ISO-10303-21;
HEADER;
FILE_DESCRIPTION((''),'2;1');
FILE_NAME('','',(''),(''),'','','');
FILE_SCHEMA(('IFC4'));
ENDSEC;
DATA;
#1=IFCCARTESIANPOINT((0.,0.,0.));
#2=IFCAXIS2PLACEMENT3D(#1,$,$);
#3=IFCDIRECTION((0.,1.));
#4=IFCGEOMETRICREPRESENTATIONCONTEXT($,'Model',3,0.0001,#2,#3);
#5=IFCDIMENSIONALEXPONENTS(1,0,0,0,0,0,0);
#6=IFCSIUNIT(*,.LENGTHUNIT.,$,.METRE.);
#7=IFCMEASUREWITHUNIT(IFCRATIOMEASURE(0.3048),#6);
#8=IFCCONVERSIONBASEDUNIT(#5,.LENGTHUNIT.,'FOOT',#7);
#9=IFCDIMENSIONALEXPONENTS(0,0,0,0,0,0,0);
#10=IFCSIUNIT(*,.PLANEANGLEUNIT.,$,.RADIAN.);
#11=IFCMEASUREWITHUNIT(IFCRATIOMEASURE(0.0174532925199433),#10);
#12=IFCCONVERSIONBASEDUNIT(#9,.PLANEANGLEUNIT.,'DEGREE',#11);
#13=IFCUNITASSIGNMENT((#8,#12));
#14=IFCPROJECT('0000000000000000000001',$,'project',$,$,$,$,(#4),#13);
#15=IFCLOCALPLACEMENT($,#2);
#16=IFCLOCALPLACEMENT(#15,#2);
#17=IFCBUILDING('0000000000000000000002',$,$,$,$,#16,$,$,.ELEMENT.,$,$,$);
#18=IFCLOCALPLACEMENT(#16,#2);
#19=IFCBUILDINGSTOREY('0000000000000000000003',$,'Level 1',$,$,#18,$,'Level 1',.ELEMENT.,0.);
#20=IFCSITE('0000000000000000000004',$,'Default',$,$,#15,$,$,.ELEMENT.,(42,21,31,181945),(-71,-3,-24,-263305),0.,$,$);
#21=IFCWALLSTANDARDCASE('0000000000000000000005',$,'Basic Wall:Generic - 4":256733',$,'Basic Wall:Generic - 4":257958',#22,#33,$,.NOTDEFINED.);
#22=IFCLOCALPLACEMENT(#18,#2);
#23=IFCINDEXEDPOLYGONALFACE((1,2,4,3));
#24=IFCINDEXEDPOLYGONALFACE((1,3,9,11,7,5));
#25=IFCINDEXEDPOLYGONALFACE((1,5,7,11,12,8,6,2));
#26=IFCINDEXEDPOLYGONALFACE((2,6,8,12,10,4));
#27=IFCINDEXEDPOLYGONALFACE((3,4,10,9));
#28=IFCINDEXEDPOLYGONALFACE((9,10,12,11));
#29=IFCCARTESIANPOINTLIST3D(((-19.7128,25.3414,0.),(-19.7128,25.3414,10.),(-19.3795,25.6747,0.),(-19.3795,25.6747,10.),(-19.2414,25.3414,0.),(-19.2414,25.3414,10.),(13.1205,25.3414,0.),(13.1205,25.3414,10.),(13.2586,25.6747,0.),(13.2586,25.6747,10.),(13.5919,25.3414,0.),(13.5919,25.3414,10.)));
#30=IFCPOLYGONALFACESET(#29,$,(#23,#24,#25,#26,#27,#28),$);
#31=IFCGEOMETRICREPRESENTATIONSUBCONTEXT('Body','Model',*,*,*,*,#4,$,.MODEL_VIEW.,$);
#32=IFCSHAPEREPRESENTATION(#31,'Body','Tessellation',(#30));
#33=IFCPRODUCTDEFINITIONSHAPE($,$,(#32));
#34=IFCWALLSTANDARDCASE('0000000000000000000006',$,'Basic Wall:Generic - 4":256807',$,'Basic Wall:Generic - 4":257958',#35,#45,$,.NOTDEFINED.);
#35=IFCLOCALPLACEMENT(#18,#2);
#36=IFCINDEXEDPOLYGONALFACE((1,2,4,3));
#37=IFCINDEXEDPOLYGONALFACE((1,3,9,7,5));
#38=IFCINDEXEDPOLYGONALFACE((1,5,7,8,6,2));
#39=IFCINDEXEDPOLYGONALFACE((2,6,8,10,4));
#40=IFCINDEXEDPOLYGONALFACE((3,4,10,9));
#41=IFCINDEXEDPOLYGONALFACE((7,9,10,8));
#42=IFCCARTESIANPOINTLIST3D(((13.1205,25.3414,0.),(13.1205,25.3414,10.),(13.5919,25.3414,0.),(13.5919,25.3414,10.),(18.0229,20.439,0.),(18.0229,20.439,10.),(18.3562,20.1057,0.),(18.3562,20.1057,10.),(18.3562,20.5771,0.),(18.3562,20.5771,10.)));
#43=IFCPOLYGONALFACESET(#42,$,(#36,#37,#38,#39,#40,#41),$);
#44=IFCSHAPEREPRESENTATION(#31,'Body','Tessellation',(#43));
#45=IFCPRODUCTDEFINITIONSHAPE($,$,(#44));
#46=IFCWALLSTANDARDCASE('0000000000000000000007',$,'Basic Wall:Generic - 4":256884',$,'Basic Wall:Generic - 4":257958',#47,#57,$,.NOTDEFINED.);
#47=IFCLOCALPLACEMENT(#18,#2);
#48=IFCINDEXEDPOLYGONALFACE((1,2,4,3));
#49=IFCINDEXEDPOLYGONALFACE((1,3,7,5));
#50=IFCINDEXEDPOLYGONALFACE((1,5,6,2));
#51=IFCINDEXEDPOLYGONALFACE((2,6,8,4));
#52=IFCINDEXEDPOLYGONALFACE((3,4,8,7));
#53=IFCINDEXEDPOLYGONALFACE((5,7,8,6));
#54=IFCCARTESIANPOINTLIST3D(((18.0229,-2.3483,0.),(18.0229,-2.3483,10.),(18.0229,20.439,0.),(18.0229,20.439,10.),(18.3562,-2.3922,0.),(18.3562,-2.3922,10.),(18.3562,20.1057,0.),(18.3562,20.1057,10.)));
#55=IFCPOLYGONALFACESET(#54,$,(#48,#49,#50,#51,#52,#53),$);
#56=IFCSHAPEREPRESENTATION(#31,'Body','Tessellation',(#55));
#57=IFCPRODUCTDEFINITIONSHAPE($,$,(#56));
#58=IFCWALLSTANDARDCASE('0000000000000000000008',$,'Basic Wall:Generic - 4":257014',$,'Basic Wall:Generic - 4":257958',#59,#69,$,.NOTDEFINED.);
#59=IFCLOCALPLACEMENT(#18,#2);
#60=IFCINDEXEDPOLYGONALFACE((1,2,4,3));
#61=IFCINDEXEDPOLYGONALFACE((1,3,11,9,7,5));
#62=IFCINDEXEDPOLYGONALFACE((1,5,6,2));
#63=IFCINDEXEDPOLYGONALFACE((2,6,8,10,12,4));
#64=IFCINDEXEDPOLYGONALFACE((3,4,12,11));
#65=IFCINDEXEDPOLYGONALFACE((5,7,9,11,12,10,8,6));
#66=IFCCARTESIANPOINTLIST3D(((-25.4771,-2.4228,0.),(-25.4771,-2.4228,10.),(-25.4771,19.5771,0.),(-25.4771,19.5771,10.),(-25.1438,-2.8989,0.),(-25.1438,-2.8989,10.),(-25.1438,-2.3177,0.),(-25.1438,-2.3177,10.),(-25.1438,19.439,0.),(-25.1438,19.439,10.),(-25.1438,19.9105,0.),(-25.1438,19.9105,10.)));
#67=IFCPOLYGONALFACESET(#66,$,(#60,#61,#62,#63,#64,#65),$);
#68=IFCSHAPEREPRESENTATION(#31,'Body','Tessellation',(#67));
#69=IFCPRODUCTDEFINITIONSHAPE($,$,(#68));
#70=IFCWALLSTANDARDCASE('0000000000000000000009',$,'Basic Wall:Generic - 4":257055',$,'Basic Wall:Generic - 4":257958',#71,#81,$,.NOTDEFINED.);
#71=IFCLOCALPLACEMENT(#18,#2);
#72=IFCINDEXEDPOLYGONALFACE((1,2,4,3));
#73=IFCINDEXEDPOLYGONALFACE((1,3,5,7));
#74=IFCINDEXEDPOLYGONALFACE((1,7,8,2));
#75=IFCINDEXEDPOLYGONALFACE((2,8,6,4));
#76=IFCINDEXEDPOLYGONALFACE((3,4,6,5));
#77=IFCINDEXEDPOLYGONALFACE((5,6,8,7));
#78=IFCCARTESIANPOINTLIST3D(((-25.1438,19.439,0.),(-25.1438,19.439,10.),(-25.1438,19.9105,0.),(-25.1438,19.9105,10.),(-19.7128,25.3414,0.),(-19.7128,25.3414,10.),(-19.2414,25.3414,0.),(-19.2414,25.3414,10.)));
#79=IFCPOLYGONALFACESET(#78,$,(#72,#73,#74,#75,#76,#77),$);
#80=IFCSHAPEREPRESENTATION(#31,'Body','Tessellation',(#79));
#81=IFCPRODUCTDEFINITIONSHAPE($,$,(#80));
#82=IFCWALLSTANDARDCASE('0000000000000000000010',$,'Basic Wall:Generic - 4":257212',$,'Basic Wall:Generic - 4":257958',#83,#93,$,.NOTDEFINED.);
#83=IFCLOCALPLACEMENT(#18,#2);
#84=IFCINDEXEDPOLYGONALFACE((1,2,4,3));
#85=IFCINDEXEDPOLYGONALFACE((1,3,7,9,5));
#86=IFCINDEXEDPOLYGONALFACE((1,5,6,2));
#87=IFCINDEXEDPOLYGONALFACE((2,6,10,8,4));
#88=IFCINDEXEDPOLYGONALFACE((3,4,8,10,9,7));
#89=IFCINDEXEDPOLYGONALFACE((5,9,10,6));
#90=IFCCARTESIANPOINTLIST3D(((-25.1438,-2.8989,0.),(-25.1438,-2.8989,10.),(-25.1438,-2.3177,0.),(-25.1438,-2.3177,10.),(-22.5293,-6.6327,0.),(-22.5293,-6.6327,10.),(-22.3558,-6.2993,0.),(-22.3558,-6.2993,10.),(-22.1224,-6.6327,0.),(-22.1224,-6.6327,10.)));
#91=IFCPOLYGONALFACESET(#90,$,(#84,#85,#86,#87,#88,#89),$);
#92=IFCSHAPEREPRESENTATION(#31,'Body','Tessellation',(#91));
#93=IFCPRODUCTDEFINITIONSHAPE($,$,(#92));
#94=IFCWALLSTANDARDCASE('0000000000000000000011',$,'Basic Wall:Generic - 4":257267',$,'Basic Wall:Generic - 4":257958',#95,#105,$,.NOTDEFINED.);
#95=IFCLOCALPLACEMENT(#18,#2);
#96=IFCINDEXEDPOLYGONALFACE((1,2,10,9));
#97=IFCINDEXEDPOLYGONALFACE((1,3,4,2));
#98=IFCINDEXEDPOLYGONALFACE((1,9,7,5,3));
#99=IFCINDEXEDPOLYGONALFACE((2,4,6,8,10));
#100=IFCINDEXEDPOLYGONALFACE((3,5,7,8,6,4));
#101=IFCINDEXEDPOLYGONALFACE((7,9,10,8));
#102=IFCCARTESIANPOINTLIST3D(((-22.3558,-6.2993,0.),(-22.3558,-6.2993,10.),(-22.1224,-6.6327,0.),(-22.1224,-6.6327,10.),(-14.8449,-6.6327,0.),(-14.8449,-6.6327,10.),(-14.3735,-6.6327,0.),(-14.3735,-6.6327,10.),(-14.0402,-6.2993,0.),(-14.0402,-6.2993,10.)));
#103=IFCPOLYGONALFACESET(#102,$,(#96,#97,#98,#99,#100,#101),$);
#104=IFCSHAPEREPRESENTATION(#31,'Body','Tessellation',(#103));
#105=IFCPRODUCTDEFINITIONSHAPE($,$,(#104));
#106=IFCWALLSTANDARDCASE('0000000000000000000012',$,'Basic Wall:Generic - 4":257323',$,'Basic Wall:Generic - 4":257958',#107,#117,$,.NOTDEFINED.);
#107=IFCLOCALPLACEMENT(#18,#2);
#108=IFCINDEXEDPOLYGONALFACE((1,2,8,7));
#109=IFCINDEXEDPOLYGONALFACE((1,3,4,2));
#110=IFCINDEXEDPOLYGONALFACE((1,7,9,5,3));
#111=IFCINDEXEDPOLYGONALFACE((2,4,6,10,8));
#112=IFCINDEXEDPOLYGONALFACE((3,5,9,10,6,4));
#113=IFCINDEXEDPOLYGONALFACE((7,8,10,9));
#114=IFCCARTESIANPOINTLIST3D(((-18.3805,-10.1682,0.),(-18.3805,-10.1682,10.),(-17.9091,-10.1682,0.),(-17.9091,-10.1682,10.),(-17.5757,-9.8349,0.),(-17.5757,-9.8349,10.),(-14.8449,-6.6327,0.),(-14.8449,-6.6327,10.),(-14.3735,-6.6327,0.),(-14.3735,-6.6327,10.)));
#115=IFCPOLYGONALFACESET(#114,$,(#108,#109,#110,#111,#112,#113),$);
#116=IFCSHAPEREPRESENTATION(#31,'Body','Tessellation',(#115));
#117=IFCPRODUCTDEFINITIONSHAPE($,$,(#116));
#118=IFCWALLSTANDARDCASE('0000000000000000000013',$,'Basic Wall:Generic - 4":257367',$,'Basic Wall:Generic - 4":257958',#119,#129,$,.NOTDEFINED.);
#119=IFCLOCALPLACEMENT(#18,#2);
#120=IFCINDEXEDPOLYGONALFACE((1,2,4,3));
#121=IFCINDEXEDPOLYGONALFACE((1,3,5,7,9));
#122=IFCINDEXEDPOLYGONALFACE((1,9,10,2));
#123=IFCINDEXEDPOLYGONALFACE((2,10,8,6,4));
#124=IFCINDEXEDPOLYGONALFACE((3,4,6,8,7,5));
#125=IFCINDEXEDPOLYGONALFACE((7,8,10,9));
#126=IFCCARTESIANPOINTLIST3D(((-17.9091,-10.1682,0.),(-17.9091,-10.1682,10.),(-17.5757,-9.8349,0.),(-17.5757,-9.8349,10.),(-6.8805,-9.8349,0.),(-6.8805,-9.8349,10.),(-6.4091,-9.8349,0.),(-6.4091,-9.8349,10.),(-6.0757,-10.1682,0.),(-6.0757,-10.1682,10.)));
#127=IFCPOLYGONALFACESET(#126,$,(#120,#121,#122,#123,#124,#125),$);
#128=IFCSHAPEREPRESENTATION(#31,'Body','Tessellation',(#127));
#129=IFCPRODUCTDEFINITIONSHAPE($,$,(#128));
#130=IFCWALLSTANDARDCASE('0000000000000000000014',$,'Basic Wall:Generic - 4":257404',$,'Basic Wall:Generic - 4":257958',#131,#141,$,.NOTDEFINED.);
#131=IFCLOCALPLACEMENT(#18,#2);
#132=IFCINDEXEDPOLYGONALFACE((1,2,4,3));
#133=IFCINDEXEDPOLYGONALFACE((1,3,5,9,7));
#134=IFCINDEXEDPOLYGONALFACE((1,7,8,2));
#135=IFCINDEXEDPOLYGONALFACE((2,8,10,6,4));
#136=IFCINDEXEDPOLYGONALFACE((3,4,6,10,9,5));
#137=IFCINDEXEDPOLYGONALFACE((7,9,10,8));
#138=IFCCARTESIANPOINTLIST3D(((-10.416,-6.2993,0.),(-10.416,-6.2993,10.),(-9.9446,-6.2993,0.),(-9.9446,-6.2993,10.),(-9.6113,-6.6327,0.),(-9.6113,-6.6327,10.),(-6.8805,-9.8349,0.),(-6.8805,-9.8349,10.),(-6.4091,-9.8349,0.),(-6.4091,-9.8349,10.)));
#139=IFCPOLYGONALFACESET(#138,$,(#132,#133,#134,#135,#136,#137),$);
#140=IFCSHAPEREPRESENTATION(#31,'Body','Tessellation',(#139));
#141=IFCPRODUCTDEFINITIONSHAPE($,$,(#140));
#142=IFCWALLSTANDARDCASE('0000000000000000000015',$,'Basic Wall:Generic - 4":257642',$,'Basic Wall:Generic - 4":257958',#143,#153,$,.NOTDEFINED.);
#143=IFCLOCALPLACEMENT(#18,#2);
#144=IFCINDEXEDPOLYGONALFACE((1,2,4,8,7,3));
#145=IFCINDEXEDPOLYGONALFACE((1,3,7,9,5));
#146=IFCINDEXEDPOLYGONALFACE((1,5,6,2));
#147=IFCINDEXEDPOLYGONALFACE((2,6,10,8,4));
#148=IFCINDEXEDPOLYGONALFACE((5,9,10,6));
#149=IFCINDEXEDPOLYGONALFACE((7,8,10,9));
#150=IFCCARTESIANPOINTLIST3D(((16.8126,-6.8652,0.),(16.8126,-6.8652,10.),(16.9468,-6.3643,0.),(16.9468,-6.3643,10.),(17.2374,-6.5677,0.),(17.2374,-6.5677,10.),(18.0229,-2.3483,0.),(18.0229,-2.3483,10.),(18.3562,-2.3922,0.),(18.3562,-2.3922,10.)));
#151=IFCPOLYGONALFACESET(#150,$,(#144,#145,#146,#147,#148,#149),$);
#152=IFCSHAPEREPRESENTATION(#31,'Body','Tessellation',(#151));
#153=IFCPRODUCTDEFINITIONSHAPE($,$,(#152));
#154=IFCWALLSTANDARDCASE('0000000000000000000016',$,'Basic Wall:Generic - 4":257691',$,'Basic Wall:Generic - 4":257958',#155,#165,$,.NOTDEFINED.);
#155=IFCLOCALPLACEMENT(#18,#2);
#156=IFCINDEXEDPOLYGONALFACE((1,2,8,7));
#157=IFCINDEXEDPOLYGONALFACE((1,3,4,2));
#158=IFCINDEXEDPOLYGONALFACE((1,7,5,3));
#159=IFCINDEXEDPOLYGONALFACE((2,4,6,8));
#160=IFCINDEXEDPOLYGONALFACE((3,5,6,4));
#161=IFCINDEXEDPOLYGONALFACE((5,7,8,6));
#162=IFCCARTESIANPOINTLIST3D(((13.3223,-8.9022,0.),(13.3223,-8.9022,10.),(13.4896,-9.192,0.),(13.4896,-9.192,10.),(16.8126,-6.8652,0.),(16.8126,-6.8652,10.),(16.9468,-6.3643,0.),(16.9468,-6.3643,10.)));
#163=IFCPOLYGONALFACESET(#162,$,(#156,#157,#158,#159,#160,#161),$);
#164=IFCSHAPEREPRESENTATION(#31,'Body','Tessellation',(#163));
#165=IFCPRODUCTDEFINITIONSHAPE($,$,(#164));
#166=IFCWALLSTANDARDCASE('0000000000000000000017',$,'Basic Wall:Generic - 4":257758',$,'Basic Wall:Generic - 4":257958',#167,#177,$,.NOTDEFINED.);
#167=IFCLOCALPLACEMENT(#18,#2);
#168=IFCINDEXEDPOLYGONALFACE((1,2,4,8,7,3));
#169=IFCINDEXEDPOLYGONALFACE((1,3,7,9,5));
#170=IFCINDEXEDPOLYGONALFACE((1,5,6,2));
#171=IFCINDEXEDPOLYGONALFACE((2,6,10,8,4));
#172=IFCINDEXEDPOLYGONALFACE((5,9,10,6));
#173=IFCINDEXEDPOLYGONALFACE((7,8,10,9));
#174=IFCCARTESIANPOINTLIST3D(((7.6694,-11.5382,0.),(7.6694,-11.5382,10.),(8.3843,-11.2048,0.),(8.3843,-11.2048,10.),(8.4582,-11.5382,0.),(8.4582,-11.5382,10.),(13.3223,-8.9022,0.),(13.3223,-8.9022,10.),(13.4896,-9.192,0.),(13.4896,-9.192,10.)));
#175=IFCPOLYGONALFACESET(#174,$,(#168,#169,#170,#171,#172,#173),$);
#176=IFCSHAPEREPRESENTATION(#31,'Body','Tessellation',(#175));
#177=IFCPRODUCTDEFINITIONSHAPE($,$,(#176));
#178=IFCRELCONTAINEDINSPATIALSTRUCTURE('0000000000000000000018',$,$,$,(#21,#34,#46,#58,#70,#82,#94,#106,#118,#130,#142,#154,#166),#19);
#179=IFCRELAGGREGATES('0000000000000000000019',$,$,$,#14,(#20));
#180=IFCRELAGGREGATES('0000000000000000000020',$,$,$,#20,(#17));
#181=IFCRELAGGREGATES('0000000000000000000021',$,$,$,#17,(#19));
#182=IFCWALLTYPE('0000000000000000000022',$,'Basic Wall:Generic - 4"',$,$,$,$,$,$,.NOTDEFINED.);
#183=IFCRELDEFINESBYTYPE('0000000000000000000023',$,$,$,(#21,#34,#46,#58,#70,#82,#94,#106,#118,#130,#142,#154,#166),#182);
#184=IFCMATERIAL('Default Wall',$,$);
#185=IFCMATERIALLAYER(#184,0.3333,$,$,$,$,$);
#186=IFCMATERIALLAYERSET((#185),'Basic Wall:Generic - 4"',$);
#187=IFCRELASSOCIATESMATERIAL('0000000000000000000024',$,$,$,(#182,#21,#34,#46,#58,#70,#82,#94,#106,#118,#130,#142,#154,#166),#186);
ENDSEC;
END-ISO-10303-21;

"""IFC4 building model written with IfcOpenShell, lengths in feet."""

from ifc_helpers import new_model, entity, si_unit, converted_unit, direction, frame, origin, place, context, subcontext, project, spatial, polyline, outline, extrude, material, layer, layer_set, layer_usage, type_object, element, save


model = new_model("IFC4")

# Units and contexts
model_context = context("Model", 3, precision=0.0001, world=origin(), true_north=direction((0.0, 1.0)))
body_context = subcontext(model_context, "Body", "Model", "MODEL_VIEW")
ifc_project = project(units=[converted_unit("LENGTHUNIT", "FOOT", entity("IfcRatioMeasure", 0.3048), si_unit("LENGTHUNIT", "METRE"), dimensions=[1, 0, 0, 0, 0, 0, 0]), converted_unit("PLANEANGLEUNIT", "DEGREE", entity("IfcRatioMeasure", 0.0174532925199433), si_unit("PLANEANGLEUNIT", "RADIAN"), dimensions=[0, 0, 0, 0, 0, 0, 0])], contexts=[model_context])

# Site, building, storey
site_placement = place(None, origin())
site = spatial("IfcSite", under=ifc_project, at=site_placement, Name="Default", CompositionType="ELEMENT", RefLatitude=(42, 21, 31, 181945), RefLongitude=(-71, -3, -24, -263305), RefElevation=0.0)
building_placement = place(site_placement, origin())
building = spatial("IfcBuilding", under=site, at=building_placement, CompositionType="ELEMENT")
storey_placement = place(building_placement, origin())
storey = spatial("IfcBuildingStorey", under=building, at=storey_placement, Name="Level 1", LongName="Level 1", CompositionType="ELEMENT", Elevation=0.0)

# Walls
ifc_material = material(Name="Default Wall")
ifc_layer = layer(ifc_material, 0.3333)
ifc_layer_set = layer_set([ifc_layer], Name="Basic Wall:Generic - 4\"")
ifc_layer_usage_1 = layer_usage(ifc_layer_set, "AXIS2", "NEGATIVE", 0.1667)
wall_type = type_object("IfcWallType", Name="Basic Wall:Generic - 4\"", PredefinedType="NOTDEFINED", material=ifc_layer_set)
wall_1_placement = place(storey_placement, frame((-19.7128, 25.5081, 0.0)))
element("IfcWallStandardCase", 1, at=wall_1_placement, inside=storey, type_object=wall_type, material=ifc_layer_usage_1, Name="Basic Wall:Generic - 4\":256733", ObjectType="Basic Wall:Generic - 4\":257958", PredefinedType="NOTDEFINED", context=body_context, shape_type="SweptSolid", body=[
    extrude(outline(polyline([(33.3047, -0.1667), (32.9714, 0.1667), (0.3333, 0.1667), (0.0, -0.1667), (0.4714, -0.1667), (32.8333, -0.1667), (33.3047, -0.1667)])), origin(), (0.0, 0.0, 1.0), 10.0),
])
ifc_layer_usage_2 = layer_usage(ifc_layer_set, "AXIS2", "NEGATIVE", 0.1667)
wall_2_placement = place(storey_placement, frame((13.2384, 25.4593, 0.0), z_axis=(0.0, 0.0, 1.0), x_axis=(0.707107, -0.707107, 0.0)))
element("IfcWallStandardCase", 2, at=wall_2_placement, inside=storey, type_object=wall_type, material=ifc_layer_usage_2, Name="Basic Wall:Generic - 4\":256807", ObjectType="Basic Wall:Generic - 4\":257958", PredefinedType="NOTDEFINED", context=body_context, shape_type="SweptSolid", body=[
    extrude(outline(polyline([(7.4044, -0.1667), (7.0711, 0.1667), (0.3333, 0.1667), (0.0, -0.1667), (6.933, -0.1667), (7.4044, -0.1667)])), origin(), (0.0, 0.0, 1.0), 10.0),
])
ifc_layer_usage_3 = layer_usage(ifc_layer_set, "AXIS2", "NEGATIVE", 0.1667)
wall_3_placement = place(storey_placement, frame((18.1896, 20.439, 0.0), z_axis=(0.0, 0.0, 1.0), x_axis=(0.0, -1.0, 0.0)))
element("IfcWallStandardCase", 3, at=wall_3_placement, inside=storey, type_object=wall_type, material=ifc_layer_usage_3, Name="Basic Wall:Generic - 4\":256884", ObjectType="Basic Wall:Generic - 4\":257958", PredefinedType="NOTDEFINED", context=body_context, shape_type="SweptSolid", body=[
    extrude(outline(polyline([(22.7874, -0.1667), (22.8312, 0.1667), (0.3333, 0.1667), (0.0, -0.1667), (22.7874, -0.1667)])), origin(), (0.0, 0.0, 1.0), 10.0),
])
ifc_layer_usage_4 = layer_usage(ifc_layer_set, "AXIS2", "NEGATIVE", 0.1667)
wall_4_placement = place(storey_placement, frame((-25.3104, 19.9105, 0.0), z_axis=(0.0, 0.0, 1.0), x_axis=(0.0, -1.0, 0.0)))
element("IfcWallStandardCase", 4, at=wall_4_placement, inside=storey, type_object=wall_type, material=ifc_layer_usage_4, Name="Basic Wall:Generic - 4\":257014", ObjectType="Basic Wall:Generic - 4\":257958", PredefinedType="NOTDEFINED", context=body_context, shape_type="SweptSolid", body=[
    extrude(outline(polyline([(22.3333, -0.1667), (22.8093, 0.1667), (22.2282, 0.1667), (0.4714, 0.1667), (0.0, 0.1667), (0.3333, -0.1667), (22.3333, -0.1667)])), origin(), (0.0, 0.0, 1.0), 10.0),
])
ifc_layer_usage_5 = layer_usage(ifc_layer_set, "AXIS2", "NEGATIVE", 0.1667)
wall_5_placement = place(storey_placement, frame((-25.2616, 19.5569, 0.0), z_axis=(0.0, 0.0, 1.0), x_axis=(0.707107, 0.707107, 0.0)))
element("IfcWallStandardCase", 5, at=wall_5_placement, inside=storey, type_object=wall_type, material=ifc_layer_usage_5, Name="Basic Wall:Generic - 4\":257055", ObjectType="Basic Wall:Generic - 4\":257958", PredefinedType="NOTDEFINED", context=body_context, shape_type="SweptSolid", body=[
    extrude(outline(polyline([(8.3472, -0.1667), (8.0139, 0.1667), (0.3333, 0.1667), (0.0, -0.1667), (8.3472, -0.1667)])), origin(), (0.0, 0.0, 1.0), 10.0),
])
ifc_layer_usage_6 = layer_usage(ifc_layer_set, "AXIS2", "NEGATIVE", 0.1667)
wall_6_placement = place(storey_placement, frame((-25.2803, -2.4133, 0.0), z_axis=(0.0, 0.0, 1.0), x_axis=(0.573576, -0.819152, 0.0)))
element("IfcWallStandardCase", 6, at=wall_6_placement, inside=storey, type_object=wall_type, material=ifc_layer_usage_6, Name="Basic Wall:Generic - 4\":257212", ObjectType="Basic Wall:Generic - 4\":257958", PredefinedType="NOTDEFINED", context=body_context, shape_type="SweptSolid", body=[
    extrude(outline(polyline([(5.0342, -0.1667), (5.2676, 0.1667), (4.8607, 0.1667), (0.0, 0.1667), (0.476, -0.1667), (5.0342, -0.1667)])), origin(), (0.0, 0.0, 1.0), 10.0),
])
ifc_layer_usage_7 = layer_usage(ifc_layer_set, "AXIS2", "NEGATIVE", 0.1667)
wall_7_placement = place(storey_placement, frame((-22.3558, -6.466, 0.0)))
element("IfcWallStandardCase", 7, at=wall_7_placement, inside=storey, type_object=wall_type, material=ifc_layer_usage_7, Name="Basic Wall:Generic - 4\":257267", ObjectType="Basic Wall:Generic - 4\":257958", PredefinedType="NOTDEFINED", context=body_context, shape_type="SweptSolid", body=[
    extrude(outline(polyline([(7.9823, -0.1667), (8.3156, 0.1667), (0.0, 0.1667), (0.2334, -0.1667), (7.5109, -0.1667), (7.9823, -0.1667)])), origin(), (0.0, 0.0, 1.0), 10.0),
])
ifc_layer_usage_8 = layer_usage(ifc_layer_set, "AXIS2", "NEGATIVE", 0.1667)
wall_8_placement = place(storey_placement, frame((-14.4914, -6.5148, 0.0), z_axis=(0.0, 0.0, 1.0), x_axis=(-0.707107, -0.707107, 0.0)))
element("IfcWallStandardCase", 8, at=wall_8_placement, inside=storey, type_object=wall_type, material=ifc_layer_usage_8, Name="Basic Wall:Generic - 4\":257323", ObjectType="Basic Wall:Generic - 4\":257958", PredefinedType="NOTDEFINED", context=body_context, shape_type="SweptSolid", body=[
    extrude(outline(polyline([(5.3333, -0.1667), (5.0, 0.1667), (4.5286, 0.1667), (0.0, 0.1667), (0.3333, -0.1667), (5.3333, -0.1667)])), origin(), (0.0, 0.0, 1.0), 10.0),
])
ifc_layer_usage_9 = layer_usage(ifc_layer_set, "AXIS2", "NEGATIVE", 0.1667)
wall_9_placement = place(storey_placement, frame((-17.9091, -10.0016, 0.0)))
element("IfcWallStandardCase", 9, at=wall_9_placement, inside=storey, type_object=wall_type, material=ifc_layer_usage_9, Name="Basic Wall:Generic - 4\":257367", ObjectType="Basic Wall:Generic - 4\":257958", PredefinedType="NOTDEFINED", context=body_context, shape_type="SweptSolid", body=[
    extrude(outline(polyline([(11.8333, -0.1667), (11.5, 0.1667), (11.0286, 0.1667), (0.3333, 0.1667), (0.0, -0.1667), (11.8333, -0.1667)])), origin(), (0.0, 0.0, 1.0), 10.0),
])
ifc_layer_usage_10 = layer_usage(ifc_layer_set, "AXIS2", "NEGATIVE", 0.1667)
wall_10_placement = place(storey_placement, frame((-6.5269, -9.9527, 0.0), z_axis=(0.0, 0.0, 1.0), x_axis=(-0.707107, 0.707107, 0.0)))
element("IfcWallStandardCase", 10, at=wall_10_placement, inside=storey, type_object=wall_type, material=ifc_layer_usage_10, Name="Basic Wall:Generic - 4\":257404", ObjectType="Basic Wall:Generic - 4\":257958", PredefinedType="NOTDEFINED", context=body_context, shape_type="SweptSolid", body=[
    extrude(outline(polyline([(5.0, -0.1667), (5.3333, 0.1667), (0.3333, 0.1667), (0.0, -0.1667), (4.5286, -0.1667), (5.0, -0.1667)])), origin(), (0.0, 0.0, 1.0), 10.0),
])
ifc_layer_usage_11 = layer_usage(ifc_layer_set, "AXIS2", "NEGATIVE", 0.1667)
wall_11_placement = place(storey_placement, frame((18.1952, -2.3491, 0.0), z_axis=(0.0, 0.0, 1.0), x_axis=(-0.258819, -0.965926, 0.0)))
element("IfcWallStandardCase", 11, at=wall_11_placement, inside=storey, type_object=wall_type, material=ifc_layer_usage_11, Name="Basic Wall:Generic - 4\":257642", ObjectType="Basic Wall:Generic - 4\":257958", PredefinedType="NOTDEFINED", context=body_context, shape_type="SweptSolid", body=[
    extrude(outline(polyline([(4.7201, -0.1667), (4.3228, 0.1667), (0.0, 0.1667), (0.0439, -0.1667), (4.2015, -0.1667), (4.7201, -0.1667)])), origin(), (0.0, 0.0, 1.0), 10.0),
])
ifc_layer_usage_12 = layer_usage(ifc_layer_set, "AXIS2", "NEGATIVE", 0.1667)
wall_12_placement = place(storey_placement, frame((17.0424, -6.5008, 0.0), z_axis=(0.0, 0.0, 1.0), x_axis=(-0.819152, -0.573576, 0.0)))
element("IfcWallStandardCase", 12, at=wall_12_placement, inside=storey, type_object=wall_type, material=ifc_layer_usage_12, Name="Basic Wall:Generic - 4\":257691", ObjectType="Basic Wall:Generic - 4\":257958", PredefinedType="NOTDEFINED", context=body_context, shape_type="SweptSolid", body=[
    extrude(outline(polyline([(4.4248, -0.1667), (4.4539, 0.1667), (0.3973, 0.1667), (0.0, -0.1667), (4.4248, -0.1667)])), origin(), (0.0, 0.0, 1.0), 10.0),
])
ifc_layer_usage_13 = layer_usage(ifc_layer_set, "AXIS2", "NEGATIVE", 0.1667)
wall_13_placement = place(storey_placement, frame((13.4191, -9.0409, 0.0), z_axis=(0.0, 0.0, 1.0), x_axis=(-0.906308, -0.422618, 0.0)))
element("IfcWallStandardCase", 13, at=wall_13_placement, inside=storey, type_object=wall_type, material=ifc_layer_usage_13, Name="Basic Wall:Generic - 4\":257758", ObjectType="Basic Wall:Generic - 4\":257958", PredefinedType="NOTDEFINED", context=body_context, shape_type="SweptSolid", body=[
    extrude(outline(polyline([(6.2664, -0.1667), (5.5515, 0.1667), (0.0, 0.1667), (0.0292, -0.1667), (5.4776, -0.1667), (6.2664, -0.1667)])), origin(), (0.0, 0.0, 1.0), 10.0),
])

save(model, "model.ifc")
